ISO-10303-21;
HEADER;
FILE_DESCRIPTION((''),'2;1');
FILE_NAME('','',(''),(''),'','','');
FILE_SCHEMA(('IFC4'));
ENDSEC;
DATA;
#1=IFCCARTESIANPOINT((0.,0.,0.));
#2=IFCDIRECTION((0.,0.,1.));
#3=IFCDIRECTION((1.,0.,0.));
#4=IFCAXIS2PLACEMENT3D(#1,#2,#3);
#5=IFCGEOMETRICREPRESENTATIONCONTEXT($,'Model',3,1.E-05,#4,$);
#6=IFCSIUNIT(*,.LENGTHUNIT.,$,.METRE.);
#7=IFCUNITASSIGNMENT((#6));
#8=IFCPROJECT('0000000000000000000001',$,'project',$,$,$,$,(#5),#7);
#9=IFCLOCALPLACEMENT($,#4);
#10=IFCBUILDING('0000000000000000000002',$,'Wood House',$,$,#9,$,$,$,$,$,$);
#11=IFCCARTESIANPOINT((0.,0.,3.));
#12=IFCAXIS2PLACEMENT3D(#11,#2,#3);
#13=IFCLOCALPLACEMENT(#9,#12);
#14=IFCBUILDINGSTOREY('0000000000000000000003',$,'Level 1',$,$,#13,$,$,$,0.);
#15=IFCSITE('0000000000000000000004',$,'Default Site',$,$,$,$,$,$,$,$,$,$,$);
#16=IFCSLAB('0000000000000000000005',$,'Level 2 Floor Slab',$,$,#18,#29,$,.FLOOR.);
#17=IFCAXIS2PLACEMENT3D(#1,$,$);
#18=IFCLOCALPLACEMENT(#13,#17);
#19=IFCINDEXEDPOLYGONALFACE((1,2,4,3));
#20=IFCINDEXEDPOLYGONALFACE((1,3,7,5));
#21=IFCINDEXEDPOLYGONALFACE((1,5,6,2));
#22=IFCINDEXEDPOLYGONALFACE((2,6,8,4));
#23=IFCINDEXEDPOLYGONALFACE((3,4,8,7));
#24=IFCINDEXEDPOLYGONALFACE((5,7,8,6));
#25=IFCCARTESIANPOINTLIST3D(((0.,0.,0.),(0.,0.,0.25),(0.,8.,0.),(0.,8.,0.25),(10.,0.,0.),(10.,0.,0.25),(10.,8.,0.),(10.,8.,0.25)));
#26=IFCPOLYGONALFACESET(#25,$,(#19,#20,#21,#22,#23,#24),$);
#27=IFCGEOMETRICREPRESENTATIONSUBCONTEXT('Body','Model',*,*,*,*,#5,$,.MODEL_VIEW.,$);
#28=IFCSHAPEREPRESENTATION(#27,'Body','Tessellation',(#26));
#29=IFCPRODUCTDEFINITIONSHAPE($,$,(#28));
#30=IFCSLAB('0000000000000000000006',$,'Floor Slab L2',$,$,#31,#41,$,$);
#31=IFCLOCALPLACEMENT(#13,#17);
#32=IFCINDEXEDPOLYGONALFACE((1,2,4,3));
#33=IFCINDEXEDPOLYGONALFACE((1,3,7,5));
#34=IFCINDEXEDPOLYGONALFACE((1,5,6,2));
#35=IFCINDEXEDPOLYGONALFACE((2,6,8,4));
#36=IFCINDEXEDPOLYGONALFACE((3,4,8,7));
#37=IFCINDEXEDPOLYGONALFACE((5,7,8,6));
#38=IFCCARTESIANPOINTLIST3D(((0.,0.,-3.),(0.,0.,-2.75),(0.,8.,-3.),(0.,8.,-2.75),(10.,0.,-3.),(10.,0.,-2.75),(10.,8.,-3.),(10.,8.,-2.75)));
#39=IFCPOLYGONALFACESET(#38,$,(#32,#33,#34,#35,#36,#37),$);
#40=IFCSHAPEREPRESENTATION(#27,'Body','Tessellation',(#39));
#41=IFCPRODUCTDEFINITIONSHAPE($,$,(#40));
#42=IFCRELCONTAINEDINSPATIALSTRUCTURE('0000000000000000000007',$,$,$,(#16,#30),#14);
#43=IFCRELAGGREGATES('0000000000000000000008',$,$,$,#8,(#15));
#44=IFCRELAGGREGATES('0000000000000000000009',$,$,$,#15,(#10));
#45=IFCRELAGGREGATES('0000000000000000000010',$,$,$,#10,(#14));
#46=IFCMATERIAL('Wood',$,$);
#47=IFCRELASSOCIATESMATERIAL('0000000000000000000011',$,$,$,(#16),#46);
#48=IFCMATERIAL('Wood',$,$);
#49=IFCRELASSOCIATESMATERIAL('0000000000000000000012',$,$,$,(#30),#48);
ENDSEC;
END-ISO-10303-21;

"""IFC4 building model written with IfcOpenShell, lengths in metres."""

from ifc_helpers import new_model, si_unit, frame, origin, origin_with_axes, place, context, subcontext, project, spatial, polyline, outline, extrude, material, element, save


model = new_model("IFC4")

# Units and contexts
model_context = context("Model", 3, precision=1e-05, world=origin_with_axes())
body_context = subcontext(model_context, "Body", "Model", "MODEL_VIEW")
ifc_project = project(units=[si_unit("LENGTHUNIT", "METRE")], contexts=[model_context])

# Site, building, storey
site = spatial("IfcSite", under=ifc_project, Name="Default Site")
building_placement = place(None, origin_with_axes())
building = spatial("IfcBuilding", under=site, at=building_placement, Name="Wood House")
storey_placement = place(building_placement, frame((0.0, 0.0, 3.0), z_axis=(0.0, 0.0, 1.0), x_axis=(1.0, 0.0, 0.0)))
storey = spatial("IfcBuildingStorey", under=building, at=storey_placement, Name="Level 1", Elevation=0.0)

# Slabs
ifc_material_1 = material(Name="Wood")
slab_1_placement = place(None, frame((0.0, 0.0, 3.0), z_axis=(0.0, 0.0, 1.0), x_axis=(1.0, 0.0, 0.0)))
element("IfcSlab", 1, at=slab_1_placement, inside=storey, material=ifc_material_1, Name="Level 2 Floor Slab", PredefinedType="FLOOR", context=body_context, shape_type="SweptSolid", body=[
    extrude(outline(polyline([(0.0, 0.0), (10.0, 0.0), (10.0, 8.0), (0.0, 8.0), (0.0, 0.0)])), origin(), (0.0, 0.0, 1.0), 0.25),
])
ifc_material_2 = material(Name="Wood")
slab_2_placement = place(storey_placement, frame((0.0, 0.0, -3.0), z_axis=(0.0, 0.0, 1.0), x_axis=(1.0, 0.0, 0.0)))
element("IfcSlab", 2, at=slab_2_placement, inside=storey, material=ifc_material_2, Name="Floor Slab L2", context=body_context, shape_type="SweptSolid", body=[
    extrude(outline(polyline([(0.0, 0.0), (10.0, 0.0), (10.0, 8.0), (0.0, 8.0)])), origin_with_axes(), (0.0, 0.0, 1.0), 0.25),
])

save(model, "model.ifc")
